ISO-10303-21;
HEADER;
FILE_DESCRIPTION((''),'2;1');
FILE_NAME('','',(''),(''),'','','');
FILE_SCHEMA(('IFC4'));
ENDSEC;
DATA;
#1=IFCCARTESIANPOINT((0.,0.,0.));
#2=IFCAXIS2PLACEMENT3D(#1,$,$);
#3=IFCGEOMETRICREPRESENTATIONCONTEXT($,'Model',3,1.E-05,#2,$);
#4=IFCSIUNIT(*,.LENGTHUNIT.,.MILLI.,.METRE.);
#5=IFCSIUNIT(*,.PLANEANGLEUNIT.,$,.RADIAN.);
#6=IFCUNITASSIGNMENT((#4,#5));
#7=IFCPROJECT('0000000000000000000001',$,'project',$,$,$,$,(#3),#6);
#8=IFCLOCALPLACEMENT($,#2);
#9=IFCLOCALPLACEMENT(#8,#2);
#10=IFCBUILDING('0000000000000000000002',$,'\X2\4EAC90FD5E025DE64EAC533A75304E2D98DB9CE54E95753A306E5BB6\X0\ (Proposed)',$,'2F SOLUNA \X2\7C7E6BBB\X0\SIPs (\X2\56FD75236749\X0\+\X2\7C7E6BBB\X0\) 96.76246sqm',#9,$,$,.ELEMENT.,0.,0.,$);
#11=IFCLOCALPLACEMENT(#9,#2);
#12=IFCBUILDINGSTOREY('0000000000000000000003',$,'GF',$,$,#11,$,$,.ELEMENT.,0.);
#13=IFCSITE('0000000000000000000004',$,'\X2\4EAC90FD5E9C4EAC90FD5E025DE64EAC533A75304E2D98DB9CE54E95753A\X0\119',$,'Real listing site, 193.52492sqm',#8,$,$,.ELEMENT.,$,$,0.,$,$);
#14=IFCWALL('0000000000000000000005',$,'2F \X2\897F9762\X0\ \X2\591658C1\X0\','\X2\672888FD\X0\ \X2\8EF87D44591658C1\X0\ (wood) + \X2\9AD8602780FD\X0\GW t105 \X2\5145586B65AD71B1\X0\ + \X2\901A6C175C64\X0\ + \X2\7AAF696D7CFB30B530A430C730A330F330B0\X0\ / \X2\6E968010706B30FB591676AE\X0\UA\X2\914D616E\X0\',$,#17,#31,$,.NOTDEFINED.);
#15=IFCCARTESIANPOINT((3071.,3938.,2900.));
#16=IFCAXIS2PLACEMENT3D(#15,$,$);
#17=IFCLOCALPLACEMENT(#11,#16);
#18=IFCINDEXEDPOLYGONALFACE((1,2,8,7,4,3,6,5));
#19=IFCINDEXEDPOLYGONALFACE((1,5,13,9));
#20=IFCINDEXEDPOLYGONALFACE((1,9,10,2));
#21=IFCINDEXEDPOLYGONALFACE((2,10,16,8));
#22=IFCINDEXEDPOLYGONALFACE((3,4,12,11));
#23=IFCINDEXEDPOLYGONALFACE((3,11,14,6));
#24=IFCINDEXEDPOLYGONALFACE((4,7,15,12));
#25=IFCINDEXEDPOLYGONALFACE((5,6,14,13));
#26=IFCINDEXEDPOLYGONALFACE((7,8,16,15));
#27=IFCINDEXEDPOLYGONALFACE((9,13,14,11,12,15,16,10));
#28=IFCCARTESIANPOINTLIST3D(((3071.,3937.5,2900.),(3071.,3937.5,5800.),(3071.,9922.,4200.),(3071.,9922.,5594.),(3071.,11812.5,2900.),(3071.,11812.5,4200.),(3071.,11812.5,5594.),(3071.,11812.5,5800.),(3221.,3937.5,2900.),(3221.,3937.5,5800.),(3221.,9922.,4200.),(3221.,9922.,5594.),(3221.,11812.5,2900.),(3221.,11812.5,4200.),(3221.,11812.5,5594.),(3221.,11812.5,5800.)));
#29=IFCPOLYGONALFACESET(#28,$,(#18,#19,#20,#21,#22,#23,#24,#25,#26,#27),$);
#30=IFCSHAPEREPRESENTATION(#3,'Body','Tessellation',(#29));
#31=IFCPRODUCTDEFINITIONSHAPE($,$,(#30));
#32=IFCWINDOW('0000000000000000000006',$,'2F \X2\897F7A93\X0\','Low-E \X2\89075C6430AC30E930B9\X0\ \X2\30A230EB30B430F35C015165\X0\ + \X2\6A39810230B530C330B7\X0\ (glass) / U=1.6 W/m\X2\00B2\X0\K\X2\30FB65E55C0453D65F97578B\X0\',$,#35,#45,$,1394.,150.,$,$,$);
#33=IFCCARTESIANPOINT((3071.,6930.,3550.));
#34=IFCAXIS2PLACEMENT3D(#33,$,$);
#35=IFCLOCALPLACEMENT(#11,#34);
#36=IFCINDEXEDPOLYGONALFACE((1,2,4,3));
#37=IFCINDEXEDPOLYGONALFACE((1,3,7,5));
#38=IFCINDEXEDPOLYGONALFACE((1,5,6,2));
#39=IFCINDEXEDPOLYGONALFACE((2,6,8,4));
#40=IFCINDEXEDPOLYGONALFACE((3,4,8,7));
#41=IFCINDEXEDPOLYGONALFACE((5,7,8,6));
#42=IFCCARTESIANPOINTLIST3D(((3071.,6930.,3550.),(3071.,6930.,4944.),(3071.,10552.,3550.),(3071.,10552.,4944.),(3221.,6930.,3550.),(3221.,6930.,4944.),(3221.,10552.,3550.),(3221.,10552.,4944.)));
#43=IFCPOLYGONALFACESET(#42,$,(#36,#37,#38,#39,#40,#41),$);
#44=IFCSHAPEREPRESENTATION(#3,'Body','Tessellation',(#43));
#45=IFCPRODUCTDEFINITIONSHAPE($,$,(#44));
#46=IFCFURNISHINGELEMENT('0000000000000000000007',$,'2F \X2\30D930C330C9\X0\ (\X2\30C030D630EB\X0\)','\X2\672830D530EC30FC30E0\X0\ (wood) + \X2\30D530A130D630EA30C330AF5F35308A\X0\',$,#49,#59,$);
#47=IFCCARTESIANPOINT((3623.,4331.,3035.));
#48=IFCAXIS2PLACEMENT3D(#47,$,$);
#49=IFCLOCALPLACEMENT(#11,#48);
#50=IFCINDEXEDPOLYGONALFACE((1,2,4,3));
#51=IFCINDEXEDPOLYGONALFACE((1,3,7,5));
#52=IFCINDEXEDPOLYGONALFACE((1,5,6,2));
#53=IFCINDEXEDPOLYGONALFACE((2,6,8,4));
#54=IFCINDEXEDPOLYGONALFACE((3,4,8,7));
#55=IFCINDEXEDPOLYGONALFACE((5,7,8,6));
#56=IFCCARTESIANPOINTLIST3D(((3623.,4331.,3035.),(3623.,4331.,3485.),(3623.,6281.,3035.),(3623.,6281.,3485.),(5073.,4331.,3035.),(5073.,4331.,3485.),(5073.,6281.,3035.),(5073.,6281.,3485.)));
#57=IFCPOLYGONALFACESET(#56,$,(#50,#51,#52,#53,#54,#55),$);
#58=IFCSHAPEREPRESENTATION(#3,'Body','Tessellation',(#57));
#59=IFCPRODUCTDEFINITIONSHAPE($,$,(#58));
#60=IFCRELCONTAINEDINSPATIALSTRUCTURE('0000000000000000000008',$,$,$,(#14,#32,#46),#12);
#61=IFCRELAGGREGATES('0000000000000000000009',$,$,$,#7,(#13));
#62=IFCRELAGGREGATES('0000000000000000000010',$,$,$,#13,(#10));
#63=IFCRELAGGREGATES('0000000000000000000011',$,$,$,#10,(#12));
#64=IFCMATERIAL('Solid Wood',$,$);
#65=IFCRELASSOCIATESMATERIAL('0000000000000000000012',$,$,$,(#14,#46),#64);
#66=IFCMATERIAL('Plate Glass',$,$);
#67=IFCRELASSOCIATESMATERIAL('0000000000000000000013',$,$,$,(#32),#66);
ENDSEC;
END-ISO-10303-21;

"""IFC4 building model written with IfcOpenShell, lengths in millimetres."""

from ifc_helpers import new_model, si_unit, frame, frame_2d, origin, place, context, project, spatial, rectangle, extrude, material, element, fill, save


model = new_model("IFC4")

# Units and contexts
model_context = context("Model", 3, precision=1e-05, world=origin())
ifc_project = project(units=[si_unit("LENGTHUNIT", "METRE", prefix="MILLI"), si_unit("PLANEANGLEUNIT", "RADIAN")], contexts=[model_context])

# Site, building, storey
site_placement = place(None, origin())
site = spatial("IfcSite", under=ifc_project, at=site_placement, Name="京都府京都市左京区田中飛鳥井町119", ObjectType="Real listing site, 193.52492sqm", CompositionType="ELEMENT", RefElevation=0.0)
building_placement = place(site_placement, origin())
building = spatial("IfcBuilding", under=site, at=building_placement, Name="京都市左京区田中飛鳥井町の家 (Proposed)", ObjectType="2F SOLUNA 籾殻SIPs (国産杉+籾殻) 96.76246sqm", CompositionType="ELEMENT", ElevationOfRefHeight=0.0, ElevationOfTerrain=0.0)
storey_placement = place(building_placement, origin())
storey = spatial("IfcBuildingStorey", under=building, at=storey_placement, Name="GF", CompositionType="ELEMENT", Elevation=0.0)

# Shared definitions
ifc_material_1 = material(Name="Solid Wood")

# Shared definitions
ifc_material_2 = material(Name="Plate Glass")

# Wall, opening, window
wall_1_placement = place(storey_placement, frame((3071.0, 3938.0, 2900.0)))
wall_1 = element("IfcWall", 1, at=wall_1_placement, inside=storey, material=ifc_material_1, Name="2F 西面 外壁", Description="木製 軸組外壁 (wood) + 高性能GW t105 充填断熱 + 通気層 + 窯業系サイディング / 準耐火・外皮UA配慮", PredefinedType="NOTDEFINED", context=model_context, shape_type="SweptSolid", body=[
    extrude(rectangle(XDim=150.0, YDim=7875.0, at=frame_2d((75.0, 3937.0))), frame((3071.0, 3938.0, 2900.0)), (0.0, 0.0, 1.0), 2900.0),
])
opening_1_placement = place(storey_placement, frame((3071.0, 6930.0, 3550.0)))
opening_1 = element("IfcOpeningElement", 2, at=opening_1_placement, cuts=wall_1, PredefinedType="NOTDEFINED", context=model_context, shape_type="SweptSolid", body=[
    extrude(rectangle(XDim=150.0, YDim=3622.0, at=frame_2d((75.0, 1811.0))), frame((3071.0, 6930.0, 3550.0)), (0.0, 0.0, 1.0), 1394.0),
])
window_1_placement = place(storey_placement, frame((3071.0, 6930.0, 3550.0)))
window_1 = element("IfcWindow", 3, at=window_1_placement, inside=storey, material=ifc_material_2, Name="2F 西窓", Description="Low-E 複層ガラス アルゴン封入 + 樹脂サッシ (glass) / U=1.6 W/m²K・日射取得型", OverallHeight=1394.0, OverallWidth=150.0, context=model_context, shape_type="SweptSolid", body=[
    extrude(rectangle(XDim=150.0, YDim=3622.0, at=frame_2d((75.0, 1811.0))), frame((3071.0, 6930.0, 3550.0)), (0.0, 0.0, 1.0), 1394.0),
])
fill(opening_1, window_1)

# Furnishing element
furnishing_placement = place(storey_placement, frame((3623.0, 4331.0, 3035.0)))
element("IfcFurnishingElement", 4, at=furnishing_placement, inside=storey, material=ifc_material_1, Name="2F ベッド (ダブル)", Description="木フレーム (wood) + ファブリック張り", context=model_context, shape_type="SweptSolid", body=[
    extrude(rectangle(XDim=1450.0, YDim=1950.0, at=frame_2d((725.0, 975.0))), frame((3623.0, 4331.0, 3035.0)), (0.0, 0.0, 1.0), 450.0),
])

save(model, "model.ifc")
